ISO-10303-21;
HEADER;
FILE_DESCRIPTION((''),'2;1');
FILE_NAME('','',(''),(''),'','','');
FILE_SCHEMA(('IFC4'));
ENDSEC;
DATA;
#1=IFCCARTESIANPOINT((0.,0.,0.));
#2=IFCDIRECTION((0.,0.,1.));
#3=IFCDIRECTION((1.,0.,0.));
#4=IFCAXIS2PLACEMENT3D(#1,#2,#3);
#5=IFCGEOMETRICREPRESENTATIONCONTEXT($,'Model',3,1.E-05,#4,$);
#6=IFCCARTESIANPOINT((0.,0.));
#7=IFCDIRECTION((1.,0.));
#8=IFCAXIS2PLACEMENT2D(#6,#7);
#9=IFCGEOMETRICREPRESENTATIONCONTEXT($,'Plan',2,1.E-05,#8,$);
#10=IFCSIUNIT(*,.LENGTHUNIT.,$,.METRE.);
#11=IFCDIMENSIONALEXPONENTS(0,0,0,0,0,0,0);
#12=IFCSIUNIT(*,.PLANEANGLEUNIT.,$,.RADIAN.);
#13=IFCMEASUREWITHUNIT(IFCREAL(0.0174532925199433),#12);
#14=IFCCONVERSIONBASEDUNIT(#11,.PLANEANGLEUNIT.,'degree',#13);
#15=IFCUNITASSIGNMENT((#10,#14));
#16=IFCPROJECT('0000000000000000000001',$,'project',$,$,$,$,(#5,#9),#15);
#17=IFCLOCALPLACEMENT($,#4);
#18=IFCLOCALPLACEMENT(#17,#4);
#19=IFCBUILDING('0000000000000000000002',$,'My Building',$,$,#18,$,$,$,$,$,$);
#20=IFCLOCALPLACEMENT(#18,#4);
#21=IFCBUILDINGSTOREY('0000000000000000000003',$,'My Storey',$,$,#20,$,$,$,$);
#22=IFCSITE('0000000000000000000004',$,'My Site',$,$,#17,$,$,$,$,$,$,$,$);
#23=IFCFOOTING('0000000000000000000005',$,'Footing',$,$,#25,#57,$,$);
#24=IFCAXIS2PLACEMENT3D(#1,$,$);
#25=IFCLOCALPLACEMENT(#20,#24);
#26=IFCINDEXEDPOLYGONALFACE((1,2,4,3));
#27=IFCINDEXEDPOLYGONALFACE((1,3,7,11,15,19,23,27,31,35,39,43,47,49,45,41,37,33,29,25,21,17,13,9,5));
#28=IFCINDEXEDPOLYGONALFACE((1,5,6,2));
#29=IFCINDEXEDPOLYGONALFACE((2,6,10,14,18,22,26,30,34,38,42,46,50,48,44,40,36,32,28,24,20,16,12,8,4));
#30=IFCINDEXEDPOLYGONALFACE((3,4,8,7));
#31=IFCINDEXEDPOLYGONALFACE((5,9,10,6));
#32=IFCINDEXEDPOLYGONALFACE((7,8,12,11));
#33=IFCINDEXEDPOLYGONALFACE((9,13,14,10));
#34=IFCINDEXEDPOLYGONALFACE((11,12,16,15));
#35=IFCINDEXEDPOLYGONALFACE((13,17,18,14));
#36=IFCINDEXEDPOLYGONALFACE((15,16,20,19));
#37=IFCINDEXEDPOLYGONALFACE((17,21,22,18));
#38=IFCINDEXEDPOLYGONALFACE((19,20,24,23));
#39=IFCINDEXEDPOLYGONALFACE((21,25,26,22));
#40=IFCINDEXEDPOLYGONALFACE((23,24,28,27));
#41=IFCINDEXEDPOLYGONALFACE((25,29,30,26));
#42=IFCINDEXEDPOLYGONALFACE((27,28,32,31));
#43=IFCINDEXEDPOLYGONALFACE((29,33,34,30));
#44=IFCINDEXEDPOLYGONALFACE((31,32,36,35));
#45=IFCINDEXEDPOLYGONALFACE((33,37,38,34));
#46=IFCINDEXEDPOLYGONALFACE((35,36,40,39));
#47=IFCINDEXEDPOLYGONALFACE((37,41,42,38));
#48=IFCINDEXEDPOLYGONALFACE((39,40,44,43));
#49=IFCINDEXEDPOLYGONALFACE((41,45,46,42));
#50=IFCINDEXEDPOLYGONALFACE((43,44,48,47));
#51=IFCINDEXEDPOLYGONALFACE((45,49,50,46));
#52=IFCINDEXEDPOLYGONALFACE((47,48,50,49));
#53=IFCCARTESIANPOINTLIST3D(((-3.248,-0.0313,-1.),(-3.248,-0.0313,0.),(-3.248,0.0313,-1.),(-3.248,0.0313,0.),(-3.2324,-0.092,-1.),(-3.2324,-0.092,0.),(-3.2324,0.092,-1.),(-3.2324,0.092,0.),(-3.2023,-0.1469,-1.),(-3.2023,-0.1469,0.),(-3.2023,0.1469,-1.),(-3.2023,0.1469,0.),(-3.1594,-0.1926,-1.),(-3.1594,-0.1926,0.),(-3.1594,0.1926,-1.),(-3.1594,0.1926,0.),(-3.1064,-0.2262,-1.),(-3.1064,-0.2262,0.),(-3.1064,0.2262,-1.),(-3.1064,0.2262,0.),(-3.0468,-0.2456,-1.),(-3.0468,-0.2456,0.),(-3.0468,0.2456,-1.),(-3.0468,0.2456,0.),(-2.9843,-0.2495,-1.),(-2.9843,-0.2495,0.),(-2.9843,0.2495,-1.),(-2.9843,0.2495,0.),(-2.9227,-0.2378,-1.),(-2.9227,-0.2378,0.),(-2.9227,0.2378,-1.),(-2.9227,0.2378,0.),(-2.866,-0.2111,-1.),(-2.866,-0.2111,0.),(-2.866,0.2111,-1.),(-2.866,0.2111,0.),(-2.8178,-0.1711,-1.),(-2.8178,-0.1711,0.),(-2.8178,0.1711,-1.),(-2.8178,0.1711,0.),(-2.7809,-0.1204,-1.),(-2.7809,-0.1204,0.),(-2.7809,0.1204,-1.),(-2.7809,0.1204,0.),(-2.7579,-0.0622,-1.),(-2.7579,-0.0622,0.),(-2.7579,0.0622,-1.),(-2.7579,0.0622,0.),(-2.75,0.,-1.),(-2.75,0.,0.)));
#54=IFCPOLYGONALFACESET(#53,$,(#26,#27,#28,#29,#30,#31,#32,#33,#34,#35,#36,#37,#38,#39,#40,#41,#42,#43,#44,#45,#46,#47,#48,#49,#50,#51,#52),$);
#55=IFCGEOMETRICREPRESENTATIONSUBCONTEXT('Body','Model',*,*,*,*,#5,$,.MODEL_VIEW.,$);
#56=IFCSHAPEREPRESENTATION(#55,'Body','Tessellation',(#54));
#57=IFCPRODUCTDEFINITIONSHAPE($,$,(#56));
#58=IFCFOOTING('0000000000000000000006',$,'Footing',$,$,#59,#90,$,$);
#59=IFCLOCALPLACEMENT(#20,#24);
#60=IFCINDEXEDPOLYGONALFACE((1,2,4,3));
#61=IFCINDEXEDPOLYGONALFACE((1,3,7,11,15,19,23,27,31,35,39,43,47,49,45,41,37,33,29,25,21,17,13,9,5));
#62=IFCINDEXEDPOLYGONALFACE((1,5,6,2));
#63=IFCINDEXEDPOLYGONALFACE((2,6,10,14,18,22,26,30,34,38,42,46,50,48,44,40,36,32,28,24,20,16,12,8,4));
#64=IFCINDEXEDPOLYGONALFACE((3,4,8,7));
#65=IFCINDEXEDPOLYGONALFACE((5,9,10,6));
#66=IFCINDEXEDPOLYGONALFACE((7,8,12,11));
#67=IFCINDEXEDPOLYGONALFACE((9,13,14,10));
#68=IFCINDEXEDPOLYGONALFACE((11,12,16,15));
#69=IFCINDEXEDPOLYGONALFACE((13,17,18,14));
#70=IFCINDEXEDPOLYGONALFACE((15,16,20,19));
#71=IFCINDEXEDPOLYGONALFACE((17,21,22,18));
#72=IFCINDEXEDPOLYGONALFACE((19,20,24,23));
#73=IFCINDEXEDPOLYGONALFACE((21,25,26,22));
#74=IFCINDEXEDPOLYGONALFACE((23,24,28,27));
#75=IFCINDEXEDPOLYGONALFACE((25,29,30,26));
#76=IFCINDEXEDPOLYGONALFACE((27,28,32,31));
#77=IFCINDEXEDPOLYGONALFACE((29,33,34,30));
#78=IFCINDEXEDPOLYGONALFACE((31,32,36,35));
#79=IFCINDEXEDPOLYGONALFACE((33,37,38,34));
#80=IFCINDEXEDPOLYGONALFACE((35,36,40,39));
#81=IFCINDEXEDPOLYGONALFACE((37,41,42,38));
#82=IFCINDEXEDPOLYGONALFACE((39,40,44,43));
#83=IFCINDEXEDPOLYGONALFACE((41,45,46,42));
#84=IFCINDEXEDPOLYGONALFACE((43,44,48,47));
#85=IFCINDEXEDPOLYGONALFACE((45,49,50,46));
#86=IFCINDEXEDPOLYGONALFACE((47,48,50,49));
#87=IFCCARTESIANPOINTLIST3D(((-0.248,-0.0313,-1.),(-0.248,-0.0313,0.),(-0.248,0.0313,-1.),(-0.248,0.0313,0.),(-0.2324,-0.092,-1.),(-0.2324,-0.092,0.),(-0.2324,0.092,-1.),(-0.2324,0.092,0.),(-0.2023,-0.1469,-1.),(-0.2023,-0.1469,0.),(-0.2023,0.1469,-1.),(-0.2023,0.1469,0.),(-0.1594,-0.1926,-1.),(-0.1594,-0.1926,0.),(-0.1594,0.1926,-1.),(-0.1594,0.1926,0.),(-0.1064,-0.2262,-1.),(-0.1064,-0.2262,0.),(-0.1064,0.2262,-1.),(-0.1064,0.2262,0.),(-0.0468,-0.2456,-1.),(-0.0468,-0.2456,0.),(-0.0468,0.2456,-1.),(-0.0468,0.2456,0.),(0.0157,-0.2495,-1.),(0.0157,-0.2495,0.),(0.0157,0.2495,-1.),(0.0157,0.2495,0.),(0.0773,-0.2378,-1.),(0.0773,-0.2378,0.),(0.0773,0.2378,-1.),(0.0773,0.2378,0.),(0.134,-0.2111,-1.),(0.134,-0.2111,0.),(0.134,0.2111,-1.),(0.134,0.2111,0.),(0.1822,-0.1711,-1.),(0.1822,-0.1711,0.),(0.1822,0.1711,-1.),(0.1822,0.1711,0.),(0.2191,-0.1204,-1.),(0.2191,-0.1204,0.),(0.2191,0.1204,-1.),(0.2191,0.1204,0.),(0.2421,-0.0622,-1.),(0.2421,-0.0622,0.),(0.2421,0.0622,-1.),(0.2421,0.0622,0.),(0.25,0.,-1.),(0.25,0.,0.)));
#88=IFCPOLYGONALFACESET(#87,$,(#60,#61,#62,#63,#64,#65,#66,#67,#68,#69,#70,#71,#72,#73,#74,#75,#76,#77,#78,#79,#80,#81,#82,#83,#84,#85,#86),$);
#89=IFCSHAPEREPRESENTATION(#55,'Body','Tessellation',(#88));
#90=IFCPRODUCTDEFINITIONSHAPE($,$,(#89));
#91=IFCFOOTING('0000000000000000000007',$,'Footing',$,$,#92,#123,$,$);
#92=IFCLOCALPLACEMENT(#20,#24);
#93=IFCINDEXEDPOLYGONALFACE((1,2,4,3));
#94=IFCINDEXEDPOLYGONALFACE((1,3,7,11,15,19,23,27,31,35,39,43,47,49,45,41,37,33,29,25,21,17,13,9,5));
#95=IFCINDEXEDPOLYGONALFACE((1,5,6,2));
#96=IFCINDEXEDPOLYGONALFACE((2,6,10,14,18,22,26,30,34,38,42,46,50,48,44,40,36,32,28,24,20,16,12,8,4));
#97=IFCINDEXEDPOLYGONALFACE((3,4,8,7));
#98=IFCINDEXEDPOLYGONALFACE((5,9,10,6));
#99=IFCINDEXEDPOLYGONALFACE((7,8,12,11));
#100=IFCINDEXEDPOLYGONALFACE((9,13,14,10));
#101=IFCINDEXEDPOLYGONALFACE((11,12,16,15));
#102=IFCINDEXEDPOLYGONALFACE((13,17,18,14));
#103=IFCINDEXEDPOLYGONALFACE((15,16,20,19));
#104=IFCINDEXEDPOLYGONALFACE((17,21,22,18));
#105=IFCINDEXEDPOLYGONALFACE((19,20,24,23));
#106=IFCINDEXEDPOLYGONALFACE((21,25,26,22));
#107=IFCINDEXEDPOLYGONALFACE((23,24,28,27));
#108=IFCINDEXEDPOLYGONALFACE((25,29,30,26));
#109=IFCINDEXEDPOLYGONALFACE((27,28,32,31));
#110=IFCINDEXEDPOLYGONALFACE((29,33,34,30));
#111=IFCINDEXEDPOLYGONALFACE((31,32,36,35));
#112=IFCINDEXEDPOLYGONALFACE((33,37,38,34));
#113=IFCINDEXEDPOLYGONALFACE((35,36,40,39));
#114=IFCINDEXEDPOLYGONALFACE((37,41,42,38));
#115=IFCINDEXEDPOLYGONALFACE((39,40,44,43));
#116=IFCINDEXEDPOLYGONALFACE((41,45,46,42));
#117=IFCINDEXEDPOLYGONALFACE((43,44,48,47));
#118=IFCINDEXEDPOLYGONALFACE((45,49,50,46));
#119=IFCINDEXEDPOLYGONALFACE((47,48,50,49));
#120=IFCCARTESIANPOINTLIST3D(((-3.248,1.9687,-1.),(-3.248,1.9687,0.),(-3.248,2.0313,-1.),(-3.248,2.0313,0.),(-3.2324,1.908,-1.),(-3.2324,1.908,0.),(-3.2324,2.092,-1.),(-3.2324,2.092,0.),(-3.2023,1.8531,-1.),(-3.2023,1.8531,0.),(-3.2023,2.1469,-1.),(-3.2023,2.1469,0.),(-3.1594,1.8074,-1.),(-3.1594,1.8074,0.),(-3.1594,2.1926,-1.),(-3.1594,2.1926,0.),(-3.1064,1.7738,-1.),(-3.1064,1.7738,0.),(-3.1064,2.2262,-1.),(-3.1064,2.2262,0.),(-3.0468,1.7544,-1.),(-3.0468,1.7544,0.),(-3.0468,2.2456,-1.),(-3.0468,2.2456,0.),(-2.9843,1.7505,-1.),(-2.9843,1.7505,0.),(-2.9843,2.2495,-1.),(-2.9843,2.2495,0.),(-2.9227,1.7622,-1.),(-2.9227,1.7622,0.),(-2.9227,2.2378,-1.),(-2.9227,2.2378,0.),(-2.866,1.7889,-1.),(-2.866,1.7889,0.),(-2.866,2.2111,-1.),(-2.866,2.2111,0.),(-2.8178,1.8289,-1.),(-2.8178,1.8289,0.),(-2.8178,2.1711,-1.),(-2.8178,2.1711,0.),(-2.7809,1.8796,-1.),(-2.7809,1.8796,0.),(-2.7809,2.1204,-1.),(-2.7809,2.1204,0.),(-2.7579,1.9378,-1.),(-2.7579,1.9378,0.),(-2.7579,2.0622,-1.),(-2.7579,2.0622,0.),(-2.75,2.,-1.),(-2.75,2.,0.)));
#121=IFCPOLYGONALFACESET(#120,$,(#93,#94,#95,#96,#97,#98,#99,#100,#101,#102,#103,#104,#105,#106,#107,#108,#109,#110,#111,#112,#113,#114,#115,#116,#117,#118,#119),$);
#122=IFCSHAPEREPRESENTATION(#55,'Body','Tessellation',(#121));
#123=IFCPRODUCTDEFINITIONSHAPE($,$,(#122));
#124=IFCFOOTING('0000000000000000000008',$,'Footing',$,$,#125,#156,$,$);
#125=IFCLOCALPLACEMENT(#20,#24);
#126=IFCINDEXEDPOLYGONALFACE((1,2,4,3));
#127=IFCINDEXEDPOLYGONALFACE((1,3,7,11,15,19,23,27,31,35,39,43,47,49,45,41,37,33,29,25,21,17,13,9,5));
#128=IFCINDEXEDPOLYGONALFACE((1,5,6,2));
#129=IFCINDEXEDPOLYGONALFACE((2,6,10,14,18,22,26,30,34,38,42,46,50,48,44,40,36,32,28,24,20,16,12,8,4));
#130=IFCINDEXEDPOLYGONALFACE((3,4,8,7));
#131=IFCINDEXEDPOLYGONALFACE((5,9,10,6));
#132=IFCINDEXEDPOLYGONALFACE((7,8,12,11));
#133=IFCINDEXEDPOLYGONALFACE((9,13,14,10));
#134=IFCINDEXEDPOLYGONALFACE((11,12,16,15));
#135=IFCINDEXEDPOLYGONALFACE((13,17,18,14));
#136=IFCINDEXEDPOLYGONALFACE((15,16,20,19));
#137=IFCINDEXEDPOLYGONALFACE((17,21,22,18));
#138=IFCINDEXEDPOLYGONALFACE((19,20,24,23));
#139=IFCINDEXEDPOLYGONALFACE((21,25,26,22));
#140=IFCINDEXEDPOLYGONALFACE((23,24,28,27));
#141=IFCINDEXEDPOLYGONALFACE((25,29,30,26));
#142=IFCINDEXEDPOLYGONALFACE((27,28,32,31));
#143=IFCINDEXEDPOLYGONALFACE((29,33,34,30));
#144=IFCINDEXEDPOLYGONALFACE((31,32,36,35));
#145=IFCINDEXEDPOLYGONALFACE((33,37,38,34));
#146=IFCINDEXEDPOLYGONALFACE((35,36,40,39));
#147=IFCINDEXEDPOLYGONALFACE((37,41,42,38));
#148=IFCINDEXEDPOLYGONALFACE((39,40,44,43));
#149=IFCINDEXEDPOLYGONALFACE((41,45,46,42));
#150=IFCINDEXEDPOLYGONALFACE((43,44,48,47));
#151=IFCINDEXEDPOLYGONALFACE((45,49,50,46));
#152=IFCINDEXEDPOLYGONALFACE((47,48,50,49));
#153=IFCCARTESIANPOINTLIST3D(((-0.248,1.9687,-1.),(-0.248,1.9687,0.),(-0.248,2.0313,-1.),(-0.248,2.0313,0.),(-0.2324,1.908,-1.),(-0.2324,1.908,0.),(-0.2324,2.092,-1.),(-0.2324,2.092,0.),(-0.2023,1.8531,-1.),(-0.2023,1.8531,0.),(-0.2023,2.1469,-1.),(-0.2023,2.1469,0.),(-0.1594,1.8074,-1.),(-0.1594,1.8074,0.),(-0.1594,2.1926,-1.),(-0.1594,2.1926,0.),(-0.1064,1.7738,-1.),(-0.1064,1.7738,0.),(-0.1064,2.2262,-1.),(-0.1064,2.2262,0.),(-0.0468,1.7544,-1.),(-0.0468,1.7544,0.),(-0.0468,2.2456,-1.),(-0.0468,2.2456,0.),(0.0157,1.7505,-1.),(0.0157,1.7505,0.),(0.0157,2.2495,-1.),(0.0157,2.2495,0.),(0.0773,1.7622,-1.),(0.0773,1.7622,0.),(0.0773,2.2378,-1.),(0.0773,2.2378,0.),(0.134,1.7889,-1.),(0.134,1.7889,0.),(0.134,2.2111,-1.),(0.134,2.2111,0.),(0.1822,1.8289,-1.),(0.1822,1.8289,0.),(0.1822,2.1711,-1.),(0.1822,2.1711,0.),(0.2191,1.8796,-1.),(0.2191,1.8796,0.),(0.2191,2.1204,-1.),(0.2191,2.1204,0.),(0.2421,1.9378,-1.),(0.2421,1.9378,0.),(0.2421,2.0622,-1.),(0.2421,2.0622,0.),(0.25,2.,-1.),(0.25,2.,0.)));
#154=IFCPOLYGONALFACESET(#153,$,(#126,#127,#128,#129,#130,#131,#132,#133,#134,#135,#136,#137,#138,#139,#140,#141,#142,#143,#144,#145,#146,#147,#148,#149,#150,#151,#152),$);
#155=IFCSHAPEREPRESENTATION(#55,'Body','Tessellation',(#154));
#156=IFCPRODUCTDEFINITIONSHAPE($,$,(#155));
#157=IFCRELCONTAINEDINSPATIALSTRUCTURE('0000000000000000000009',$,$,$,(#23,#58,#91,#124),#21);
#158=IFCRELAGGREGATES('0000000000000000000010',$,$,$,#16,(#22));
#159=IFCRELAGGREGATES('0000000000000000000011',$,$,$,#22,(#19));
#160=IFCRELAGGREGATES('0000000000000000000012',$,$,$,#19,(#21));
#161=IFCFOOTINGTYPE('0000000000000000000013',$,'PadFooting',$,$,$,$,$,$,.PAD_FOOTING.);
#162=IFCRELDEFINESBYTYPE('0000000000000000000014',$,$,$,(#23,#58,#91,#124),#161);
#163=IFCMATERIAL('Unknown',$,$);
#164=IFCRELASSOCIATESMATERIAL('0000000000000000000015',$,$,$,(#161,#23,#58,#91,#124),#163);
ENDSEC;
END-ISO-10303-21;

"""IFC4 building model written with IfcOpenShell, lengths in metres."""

from ifc_helpers import new_model, entity, si_unit, converted_unit, frame, origin_with_axes, origin_2d_with_axis, place, context, subcontext, project, spatial, circle, extrude, material, material_profile, profile_set, profile_usage, type_object, element, save


model = new_model("IFC4")

# Units and contexts
model_context = context("Model", 3, precision=1e-05, world=origin_with_axes())
plan_context = context("Plan", 2, precision=1e-05, world=origin_2d_with_axis())
body_context = subcontext(model_context, "Body", "Model", "MODEL_VIEW")
ifc_project = project(units=[si_unit("LENGTHUNIT", "METRE"), converted_unit("PLANEANGLEUNIT", "degree", entity("IfcReal", 0.0174532925199433), si_unit("PLANEANGLEUNIT", "RADIAN"), dimensions=[0, 0, 0, 0, 0, 0, 0])], contexts=[model_context, plan_context])

# Site, building, storey
site_placement = place(None, origin_with_axes())
site = spatial("IfcSite", under=ifc_project, at=site_placement, Name="My Site")
building_placement = place(site_placement, origin_with_axes())
building = spatial("IfcBuilding", under=site, at=building_placement, Name="My Building")
storey_placement = place(building_placement, origin_with_axes())
storey = spatial("IfcBuildingStorey", under=building, at=storey_placement, Name="My Storey")

# Footings
ifc_material = material(Name="Unknown")
ifc_material_profile_1 = material_profile(ifc_material, circle(Radius=0.25))
ifc_profile_set_1 = profile_set([ifc_material_profile_1], Name="Round pad")
ifc_profile_usage_1 = profile_usage(ifc_profile_set_1, cardinal=5)
footing_type = type_object("IfcFootingType", Name="PadFooting", PredefinedType="PAD_FOOTING", material=ifc_profile_set_1)
footing_1_placement = place(storey_placement, frame((-3.0, 0.0, -1.0), z_axis=(0.0, 0.0, 1.0), x_axis=(1.0, 0.0, 0.0)))
element("IfcFooting", 1, at=footing_1_placement, inside=storey, type_object=footing_type, material=ifc_profile_usage_1, Name="Footing", context=body_context, shape_type="SweptSolid", body=[
    extrude(circle(Radius=0.25), origin_with_axes(), (0.0, 0.0, 1.0), 1.0),
])
ifc_profile_usage_2 = profile_usage(ifc_profile_set_1, cardinal=5)
footing_2_placement = place(storey_placement, frame((0.0, 0.0, -1.0), z_axis=(0.0, 0.0, 1.0), x_axis=(1.0, 0.0, 0.0)))
element("IfcFooting", 2, at=footing_2_placement, inside=storey, type_object=footing_type, material=ifc_profile_usage_2, Name="Footing", context=body_context, shape_type="SweptSolid", body=[
    extrude(circle(Radius=0.25), origin_with_axes(), (0.0, 0.0, 1.0), 1.0),
])
ifc_profile_usage_3 = profile_usage(ifc_profile_set_1, cardinal=5)
footing_3_placement = place(storey_placement, frame((-3.0, 2.0, -1.0), z_axis=(0.0, 0.0, 1.0), x_axis=(1.0, 0.0, 0.0)))
element("IfcFooting", 3, at=footing_3_placement, inside=storey, type_object=footing_type, material=ifc_profile_usage_3, Name="Footing", context=body_context, shape_type="SweptSolid", body=[
    extrude(circle(Radius=0.25), origin_with_axes(), (0.0, 0.0, 1.0), 1.0),
])
ifc_profile_usage_4 = profile_usage(ifc_profile_set_1, cardinal=5)
footing_4_placement = place(storey_placement, frame((0.0, 2.0, -1.0), z_axis=(0.0, 0.0, 1.0), x_axis=(1.0, 0.0, 0.0)))
element("IfcFooting", 4, at=footing_4_placement, inside=storey, type_object=footing_type, material=ifc_profile_usage_4, Name="Footing", context=body_context, shape_type="SweptSolid", body=[
    extrude(circle(Radius=0.25), origin_with_axes(), (0.0, 0.0, 1.0), 1.0),
])

save(model, "model.ifc")
